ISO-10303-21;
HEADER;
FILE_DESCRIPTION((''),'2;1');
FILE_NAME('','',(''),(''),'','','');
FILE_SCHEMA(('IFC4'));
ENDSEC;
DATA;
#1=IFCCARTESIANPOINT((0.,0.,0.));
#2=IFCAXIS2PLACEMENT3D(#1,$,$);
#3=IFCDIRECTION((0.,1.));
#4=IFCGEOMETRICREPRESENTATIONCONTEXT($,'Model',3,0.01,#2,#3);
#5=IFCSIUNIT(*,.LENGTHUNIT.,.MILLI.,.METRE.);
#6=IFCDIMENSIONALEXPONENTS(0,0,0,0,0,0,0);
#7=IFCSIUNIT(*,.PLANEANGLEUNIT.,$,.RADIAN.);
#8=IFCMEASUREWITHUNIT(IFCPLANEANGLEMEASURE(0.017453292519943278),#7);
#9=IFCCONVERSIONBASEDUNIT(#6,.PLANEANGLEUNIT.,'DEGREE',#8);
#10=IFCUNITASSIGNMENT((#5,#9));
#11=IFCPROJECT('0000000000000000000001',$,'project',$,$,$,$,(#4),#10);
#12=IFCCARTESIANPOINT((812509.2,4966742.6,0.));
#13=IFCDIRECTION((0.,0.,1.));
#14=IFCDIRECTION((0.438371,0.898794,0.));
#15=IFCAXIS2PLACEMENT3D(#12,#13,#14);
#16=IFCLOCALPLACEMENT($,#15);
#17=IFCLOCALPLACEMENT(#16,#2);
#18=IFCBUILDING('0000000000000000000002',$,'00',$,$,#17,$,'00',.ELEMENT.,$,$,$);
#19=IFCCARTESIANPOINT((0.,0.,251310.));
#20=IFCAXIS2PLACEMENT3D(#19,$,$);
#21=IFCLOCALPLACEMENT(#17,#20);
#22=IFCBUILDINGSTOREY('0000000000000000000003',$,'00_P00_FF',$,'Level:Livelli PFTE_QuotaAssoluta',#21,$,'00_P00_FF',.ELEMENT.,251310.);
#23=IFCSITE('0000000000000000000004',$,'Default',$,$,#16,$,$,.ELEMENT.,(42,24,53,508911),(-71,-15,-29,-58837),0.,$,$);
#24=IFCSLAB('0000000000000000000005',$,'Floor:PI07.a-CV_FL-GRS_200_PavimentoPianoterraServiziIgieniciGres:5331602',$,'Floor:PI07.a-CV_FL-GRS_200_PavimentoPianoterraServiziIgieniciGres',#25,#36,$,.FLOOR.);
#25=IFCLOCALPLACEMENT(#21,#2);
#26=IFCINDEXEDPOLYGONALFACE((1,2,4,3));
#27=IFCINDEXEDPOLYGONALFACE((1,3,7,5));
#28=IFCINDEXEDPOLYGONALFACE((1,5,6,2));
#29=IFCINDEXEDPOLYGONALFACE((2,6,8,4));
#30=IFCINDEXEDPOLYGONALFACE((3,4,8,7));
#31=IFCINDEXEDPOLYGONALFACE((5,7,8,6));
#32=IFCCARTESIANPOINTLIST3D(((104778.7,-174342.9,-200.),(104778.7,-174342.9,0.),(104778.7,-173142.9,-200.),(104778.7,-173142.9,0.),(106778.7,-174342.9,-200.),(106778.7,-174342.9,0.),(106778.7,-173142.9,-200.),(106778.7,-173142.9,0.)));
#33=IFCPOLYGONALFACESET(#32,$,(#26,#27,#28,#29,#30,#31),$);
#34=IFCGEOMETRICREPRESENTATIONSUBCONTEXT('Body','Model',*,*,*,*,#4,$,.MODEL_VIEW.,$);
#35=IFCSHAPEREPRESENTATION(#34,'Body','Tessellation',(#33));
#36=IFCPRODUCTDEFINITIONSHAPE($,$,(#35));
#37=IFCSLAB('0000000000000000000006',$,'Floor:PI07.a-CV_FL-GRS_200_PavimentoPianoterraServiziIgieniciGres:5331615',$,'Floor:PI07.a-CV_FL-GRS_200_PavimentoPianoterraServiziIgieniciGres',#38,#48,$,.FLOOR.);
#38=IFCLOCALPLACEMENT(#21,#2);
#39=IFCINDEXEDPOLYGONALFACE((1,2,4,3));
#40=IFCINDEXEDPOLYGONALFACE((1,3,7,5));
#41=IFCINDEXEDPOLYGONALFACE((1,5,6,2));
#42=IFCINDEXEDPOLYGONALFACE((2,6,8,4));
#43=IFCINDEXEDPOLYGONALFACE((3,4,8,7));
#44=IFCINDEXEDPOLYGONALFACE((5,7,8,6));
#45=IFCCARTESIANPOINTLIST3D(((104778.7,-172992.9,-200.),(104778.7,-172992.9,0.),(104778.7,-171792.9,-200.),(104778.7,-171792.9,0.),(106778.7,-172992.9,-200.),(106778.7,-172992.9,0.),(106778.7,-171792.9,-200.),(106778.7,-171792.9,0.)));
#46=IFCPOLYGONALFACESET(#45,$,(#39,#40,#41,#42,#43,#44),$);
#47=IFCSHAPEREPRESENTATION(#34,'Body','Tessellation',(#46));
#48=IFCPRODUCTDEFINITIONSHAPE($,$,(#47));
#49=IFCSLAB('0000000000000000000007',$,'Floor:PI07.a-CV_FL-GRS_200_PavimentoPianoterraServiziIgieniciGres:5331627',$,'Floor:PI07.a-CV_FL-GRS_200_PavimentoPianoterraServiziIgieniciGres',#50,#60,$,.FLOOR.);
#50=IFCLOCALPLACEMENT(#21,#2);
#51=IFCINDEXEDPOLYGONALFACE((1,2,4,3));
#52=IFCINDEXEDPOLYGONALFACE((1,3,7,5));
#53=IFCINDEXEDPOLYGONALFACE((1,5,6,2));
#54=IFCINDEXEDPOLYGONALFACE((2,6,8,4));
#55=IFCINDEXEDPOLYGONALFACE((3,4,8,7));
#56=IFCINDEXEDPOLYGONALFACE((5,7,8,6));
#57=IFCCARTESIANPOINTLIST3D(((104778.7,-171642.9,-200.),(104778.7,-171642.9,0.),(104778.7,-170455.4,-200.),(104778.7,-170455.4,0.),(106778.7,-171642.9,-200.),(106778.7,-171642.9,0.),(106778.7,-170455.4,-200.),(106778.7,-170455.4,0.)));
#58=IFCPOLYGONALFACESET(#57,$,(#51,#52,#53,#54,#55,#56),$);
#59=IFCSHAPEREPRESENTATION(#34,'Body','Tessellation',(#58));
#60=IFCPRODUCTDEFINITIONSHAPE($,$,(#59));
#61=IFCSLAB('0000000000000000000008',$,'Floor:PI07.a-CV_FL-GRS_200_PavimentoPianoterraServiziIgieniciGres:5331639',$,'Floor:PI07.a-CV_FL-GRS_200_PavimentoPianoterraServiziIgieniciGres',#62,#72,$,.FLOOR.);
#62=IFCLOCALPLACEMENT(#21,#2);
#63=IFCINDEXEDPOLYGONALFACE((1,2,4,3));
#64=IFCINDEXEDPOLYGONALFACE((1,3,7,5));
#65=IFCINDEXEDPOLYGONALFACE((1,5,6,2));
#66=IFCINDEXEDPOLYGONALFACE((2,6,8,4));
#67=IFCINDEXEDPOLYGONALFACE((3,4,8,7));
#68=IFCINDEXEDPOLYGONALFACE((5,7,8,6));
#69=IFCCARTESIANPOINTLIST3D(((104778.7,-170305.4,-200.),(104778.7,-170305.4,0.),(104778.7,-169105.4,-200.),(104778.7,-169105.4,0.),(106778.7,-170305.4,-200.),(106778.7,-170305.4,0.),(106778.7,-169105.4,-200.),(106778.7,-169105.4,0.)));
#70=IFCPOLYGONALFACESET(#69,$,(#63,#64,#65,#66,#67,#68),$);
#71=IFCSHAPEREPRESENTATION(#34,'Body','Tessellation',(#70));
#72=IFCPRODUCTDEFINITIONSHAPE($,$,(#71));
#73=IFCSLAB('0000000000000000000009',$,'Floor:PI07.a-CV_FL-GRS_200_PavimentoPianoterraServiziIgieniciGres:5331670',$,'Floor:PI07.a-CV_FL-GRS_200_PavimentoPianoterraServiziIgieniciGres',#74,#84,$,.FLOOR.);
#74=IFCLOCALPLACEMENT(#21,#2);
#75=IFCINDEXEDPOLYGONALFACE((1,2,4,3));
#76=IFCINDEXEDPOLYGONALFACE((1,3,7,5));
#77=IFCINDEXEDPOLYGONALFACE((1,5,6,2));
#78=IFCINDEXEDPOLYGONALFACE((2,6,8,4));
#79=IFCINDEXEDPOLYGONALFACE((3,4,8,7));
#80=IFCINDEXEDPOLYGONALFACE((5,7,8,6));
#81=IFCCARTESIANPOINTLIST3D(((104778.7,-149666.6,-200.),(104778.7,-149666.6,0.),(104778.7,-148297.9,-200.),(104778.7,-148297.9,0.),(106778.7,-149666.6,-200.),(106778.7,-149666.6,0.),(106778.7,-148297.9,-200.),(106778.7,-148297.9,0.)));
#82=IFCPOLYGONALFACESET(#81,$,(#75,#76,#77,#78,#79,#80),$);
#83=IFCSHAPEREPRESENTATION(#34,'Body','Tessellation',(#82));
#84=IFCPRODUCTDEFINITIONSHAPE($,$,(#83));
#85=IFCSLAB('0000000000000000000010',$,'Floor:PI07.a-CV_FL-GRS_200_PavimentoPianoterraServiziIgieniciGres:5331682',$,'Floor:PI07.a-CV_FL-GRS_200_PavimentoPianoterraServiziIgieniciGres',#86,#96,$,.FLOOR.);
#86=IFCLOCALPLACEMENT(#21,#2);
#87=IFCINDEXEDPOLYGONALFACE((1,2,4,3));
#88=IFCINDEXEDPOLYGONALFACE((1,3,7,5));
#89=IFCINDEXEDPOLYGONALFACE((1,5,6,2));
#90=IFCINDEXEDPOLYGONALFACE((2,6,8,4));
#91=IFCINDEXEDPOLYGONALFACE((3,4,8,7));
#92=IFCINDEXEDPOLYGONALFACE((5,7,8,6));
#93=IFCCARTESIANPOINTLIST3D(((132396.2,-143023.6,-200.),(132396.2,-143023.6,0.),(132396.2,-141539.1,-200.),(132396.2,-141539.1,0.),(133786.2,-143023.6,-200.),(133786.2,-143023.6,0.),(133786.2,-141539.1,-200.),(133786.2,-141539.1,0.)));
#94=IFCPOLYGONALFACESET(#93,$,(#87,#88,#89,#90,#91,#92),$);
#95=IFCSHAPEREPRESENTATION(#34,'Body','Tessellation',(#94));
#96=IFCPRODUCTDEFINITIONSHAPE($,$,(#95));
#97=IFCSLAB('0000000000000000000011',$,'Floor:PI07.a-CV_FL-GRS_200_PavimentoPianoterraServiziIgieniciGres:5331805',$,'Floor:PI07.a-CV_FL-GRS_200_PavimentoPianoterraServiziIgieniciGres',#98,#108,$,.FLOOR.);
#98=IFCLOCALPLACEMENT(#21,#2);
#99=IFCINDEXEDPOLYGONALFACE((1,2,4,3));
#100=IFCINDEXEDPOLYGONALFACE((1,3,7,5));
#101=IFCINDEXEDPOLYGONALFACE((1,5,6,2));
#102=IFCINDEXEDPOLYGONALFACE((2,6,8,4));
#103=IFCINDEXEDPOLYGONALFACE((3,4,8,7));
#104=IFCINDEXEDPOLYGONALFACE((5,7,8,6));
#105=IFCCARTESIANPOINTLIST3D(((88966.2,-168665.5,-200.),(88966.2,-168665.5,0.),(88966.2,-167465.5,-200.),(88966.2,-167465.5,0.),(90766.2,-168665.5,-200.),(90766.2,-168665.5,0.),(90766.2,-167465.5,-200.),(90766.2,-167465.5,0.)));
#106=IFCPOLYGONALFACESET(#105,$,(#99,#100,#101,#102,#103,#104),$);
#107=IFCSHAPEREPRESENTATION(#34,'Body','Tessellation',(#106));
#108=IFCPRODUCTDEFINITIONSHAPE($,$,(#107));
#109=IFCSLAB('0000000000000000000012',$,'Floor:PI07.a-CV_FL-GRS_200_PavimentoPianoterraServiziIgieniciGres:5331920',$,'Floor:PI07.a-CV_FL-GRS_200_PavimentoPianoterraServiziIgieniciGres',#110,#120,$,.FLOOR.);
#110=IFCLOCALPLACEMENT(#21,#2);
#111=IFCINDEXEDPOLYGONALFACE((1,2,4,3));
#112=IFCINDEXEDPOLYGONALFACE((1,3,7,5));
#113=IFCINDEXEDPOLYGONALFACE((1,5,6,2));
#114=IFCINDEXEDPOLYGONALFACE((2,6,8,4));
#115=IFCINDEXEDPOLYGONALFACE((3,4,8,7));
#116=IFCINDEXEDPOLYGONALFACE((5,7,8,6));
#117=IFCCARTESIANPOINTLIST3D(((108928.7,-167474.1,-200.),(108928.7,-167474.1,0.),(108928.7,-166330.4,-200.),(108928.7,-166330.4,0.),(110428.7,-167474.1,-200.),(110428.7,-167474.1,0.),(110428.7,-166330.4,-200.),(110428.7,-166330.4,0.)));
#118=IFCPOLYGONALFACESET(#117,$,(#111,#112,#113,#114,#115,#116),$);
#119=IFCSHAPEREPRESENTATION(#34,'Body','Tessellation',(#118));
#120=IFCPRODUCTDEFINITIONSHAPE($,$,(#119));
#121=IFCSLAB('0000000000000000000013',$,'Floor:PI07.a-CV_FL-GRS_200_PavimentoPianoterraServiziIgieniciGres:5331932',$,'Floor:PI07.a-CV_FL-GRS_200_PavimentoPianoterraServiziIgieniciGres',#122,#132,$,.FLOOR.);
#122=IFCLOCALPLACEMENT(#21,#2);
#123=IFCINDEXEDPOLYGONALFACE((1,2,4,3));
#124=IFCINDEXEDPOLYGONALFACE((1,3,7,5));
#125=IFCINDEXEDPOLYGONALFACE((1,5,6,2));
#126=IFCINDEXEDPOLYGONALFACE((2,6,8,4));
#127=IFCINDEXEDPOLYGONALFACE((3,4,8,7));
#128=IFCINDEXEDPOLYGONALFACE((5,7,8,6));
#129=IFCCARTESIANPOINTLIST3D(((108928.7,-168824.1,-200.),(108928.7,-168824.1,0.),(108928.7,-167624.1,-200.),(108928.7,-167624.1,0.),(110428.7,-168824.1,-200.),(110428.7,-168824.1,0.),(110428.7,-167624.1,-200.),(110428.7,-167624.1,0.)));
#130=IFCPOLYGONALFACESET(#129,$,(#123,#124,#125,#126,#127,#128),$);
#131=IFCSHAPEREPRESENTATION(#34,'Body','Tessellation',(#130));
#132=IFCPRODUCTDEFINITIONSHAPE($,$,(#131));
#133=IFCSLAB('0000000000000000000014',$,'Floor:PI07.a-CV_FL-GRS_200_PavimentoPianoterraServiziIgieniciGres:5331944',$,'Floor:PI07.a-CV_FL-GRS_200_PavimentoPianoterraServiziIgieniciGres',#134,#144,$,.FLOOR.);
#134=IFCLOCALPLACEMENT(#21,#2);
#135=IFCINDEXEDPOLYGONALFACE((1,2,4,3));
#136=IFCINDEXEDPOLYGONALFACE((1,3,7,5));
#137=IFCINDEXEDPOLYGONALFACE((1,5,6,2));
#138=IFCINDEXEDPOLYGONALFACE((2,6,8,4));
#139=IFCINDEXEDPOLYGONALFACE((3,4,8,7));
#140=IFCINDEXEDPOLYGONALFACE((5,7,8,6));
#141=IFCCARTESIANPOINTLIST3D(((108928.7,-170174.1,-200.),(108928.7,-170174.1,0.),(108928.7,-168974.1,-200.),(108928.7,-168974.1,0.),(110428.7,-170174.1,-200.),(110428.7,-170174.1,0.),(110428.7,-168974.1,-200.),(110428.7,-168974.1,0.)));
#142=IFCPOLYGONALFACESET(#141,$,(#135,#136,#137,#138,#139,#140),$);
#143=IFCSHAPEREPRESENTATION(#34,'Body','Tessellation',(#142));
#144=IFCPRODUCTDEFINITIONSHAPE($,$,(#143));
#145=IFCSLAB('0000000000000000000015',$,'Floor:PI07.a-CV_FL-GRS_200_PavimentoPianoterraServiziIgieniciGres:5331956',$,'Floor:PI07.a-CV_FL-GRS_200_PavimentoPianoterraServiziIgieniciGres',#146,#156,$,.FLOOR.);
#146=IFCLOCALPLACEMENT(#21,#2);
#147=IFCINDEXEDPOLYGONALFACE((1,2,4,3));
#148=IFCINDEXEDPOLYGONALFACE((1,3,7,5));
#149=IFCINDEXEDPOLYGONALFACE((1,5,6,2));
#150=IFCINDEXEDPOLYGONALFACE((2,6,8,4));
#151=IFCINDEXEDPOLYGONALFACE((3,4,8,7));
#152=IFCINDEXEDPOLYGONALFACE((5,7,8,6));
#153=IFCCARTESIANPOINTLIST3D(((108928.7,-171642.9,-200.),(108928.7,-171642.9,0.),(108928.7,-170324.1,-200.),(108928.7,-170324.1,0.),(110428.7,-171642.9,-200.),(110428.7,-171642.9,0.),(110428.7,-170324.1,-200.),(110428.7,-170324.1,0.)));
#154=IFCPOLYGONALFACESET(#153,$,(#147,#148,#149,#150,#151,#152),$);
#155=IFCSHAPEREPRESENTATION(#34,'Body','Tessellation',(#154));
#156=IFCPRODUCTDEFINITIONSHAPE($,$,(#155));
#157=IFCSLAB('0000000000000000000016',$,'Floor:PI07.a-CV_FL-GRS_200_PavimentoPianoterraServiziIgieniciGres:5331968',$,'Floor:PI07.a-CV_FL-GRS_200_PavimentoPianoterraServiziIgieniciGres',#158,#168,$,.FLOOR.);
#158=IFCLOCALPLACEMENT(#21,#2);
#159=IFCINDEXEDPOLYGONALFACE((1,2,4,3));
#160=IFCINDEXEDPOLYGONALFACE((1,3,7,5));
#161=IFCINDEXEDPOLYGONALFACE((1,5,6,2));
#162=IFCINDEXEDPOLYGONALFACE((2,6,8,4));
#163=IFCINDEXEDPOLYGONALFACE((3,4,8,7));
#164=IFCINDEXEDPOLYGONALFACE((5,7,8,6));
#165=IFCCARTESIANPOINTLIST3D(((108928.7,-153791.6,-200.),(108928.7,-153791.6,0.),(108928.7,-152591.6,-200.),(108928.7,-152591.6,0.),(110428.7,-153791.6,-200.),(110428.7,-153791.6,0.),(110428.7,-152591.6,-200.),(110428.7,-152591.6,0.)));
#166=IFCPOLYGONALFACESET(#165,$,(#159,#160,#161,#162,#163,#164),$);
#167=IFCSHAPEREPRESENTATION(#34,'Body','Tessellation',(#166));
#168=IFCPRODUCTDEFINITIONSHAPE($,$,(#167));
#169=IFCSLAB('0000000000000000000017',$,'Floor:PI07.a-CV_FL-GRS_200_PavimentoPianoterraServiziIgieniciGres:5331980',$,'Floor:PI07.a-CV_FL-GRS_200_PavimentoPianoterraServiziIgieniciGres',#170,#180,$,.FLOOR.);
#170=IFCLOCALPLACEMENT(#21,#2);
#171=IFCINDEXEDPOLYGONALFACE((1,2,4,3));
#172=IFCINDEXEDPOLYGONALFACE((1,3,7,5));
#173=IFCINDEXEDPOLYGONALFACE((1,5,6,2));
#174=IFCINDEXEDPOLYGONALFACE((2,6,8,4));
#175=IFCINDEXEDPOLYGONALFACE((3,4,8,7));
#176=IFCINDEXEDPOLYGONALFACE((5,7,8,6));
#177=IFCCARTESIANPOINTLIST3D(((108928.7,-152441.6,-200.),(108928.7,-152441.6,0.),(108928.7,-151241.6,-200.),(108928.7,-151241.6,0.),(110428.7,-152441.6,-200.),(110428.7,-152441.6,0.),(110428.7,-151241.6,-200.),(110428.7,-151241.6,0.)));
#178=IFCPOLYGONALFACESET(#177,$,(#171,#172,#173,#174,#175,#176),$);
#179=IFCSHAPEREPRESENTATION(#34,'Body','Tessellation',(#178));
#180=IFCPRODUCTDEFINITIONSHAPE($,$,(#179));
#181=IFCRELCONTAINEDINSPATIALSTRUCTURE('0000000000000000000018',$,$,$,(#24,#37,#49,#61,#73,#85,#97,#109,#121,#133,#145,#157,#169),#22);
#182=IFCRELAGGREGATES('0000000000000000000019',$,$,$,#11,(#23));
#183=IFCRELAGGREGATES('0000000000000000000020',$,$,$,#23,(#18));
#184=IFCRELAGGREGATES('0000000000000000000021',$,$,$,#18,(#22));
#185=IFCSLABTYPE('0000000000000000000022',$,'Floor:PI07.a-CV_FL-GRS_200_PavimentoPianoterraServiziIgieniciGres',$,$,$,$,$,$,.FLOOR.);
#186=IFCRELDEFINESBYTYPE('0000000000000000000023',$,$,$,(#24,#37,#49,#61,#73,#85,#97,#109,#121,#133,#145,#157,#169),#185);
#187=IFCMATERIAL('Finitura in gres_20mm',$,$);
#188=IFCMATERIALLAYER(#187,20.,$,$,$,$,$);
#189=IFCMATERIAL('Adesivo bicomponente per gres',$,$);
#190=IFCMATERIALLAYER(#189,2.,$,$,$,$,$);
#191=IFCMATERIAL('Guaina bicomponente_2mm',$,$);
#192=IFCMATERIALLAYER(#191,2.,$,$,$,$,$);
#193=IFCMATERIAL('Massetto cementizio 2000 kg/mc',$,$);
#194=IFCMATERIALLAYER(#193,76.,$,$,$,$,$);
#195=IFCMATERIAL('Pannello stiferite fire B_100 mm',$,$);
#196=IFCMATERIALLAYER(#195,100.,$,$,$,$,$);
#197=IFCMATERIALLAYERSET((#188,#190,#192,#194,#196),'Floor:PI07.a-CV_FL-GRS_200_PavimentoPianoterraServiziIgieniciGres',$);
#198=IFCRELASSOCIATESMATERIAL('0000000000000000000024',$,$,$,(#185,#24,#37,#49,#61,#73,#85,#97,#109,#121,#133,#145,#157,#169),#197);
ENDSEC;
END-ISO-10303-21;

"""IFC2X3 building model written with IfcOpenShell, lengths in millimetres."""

from ifc_helpers import new_model, entity, si_unit, converted_unit, direction, frame, frame_2d, origin, origin_2d_with_axis, place, context, subcontext, project, spatial, rectangle, extrude, material, layer, layer_set, layer_usage, type_object, element, save


model = new_model("IFC2X3")

# Units and contexts
model_context = context("Model", 3, precision=0.01, world=origin(), true_north=direction((0.0, 1.0)))
body_context = subcontext(model_context, "Body", "Model", "MODEL_VIEW")
ifc_project = project(units=[si_unit("LENGTHUNIT", "METRE", prefix="MILLI"), converted_unit("PLANEANGLEUNIT", "DEGREE", entity("IfcPlaneAngleMeasure", 0.017453292519943278), si_unit("PLANEANGLEUNIT", "RADIAN"), dimensions=[0, 0, 0, 0, 0, 0, 0])], contexts=[model_context])

# Site, building, storey
site_placement = place(None, frame((812509.2, 4966742.6, 0.0), z_axis=(0.0, 0.0, 1.0), x_axis=(0.438371, 0.898794, 0.0)))
site = spatial("IfcSite", under=ifc_project, at=site_placement, Name="Default", CompositionType="ELEMENT", RefLatitude=(42, 24, 53, 508911), RefLongitude=(-71, -15, -29, -58837), RefElevation=0.0)
building_placement = place(site_placement, origin())
building = spatial("IfcBuilding", under=site, at=building_placement, Name="00", LongName="00", CompositionType="ELEMENT")
storey_placement = place(building_placement, frame((0.0, 0.0, 251310.0)))
storey = spatial("IfcBuildingStorey", under=building, at=storey_placement, Name="00_P00_FF", ObjectType="Level:Livelli PFTE_QuotaAssoluta", LongName="00_P00_FF", CompositionType="ELEMENT", Elevation=251310.0)

# Slabs
ifc_material_1 = material(Name="Pannello stiferite fire B_100 mm")
ifc_material_2 = material(Name="Massetto cementizio 2000 kg/mc")
ifc_material_3 = material(Name="Finitura in gres_20mm")
ifc_layer_1 = layer(ifc_material_3, 20.0)
ifc_material_4 = material(Name="Adesivo bicomponente per gres")
ifc_layer_2 = layer(ifc_material_4, 2.0)
ifc_material_5 = material(Name="Guaina bicomponente_2mm")
ifc_layer_3 = layer(ifc_material_5, 2.0)
ifc_layer_4 = layer(ifc_material_2, 76.0)
ifc_layer_5 = layer(ifc_material_1, 100.0)
ifc_layer_set_1 = layer_set([ifc_layer_1, ifc_layer_2, ifc_layer_3, ifc_layer_4, ifc_layer_5], Name="Floor:PI07.a-CV_FL-GRS_200_PavimentoPianoterraServiziIgieniciGres")
slab_type_1 = type_object("IfcSlabType", Name="Floor:PI07.a-CV_FL-GRS_200_PavimentoPianoterraServiziIgieniciGres", PredefinedType="FLOOR", material=ifc_layer_set_1)
ifc_layer_usage_1 = layer_usage(ifc_layer_set_1, "AXIS3", "POSITIVE", 0.0)
slab_1_placement = place(storey_placement, origin())
element("IfcSlab", 1, at=slab_1_placement, inside=storey, type_object=slab_type_1, material=ifc_layer_usage_1, Name="Floor:PI07.a-CV_FL-GRS_200_PavimentoPianoterraServiziIgieniciGres:5331602", ObjectType="Floor:PI07.a-CV_FL-GRS_200_PavimentoPianoterraServiziIgieniciGres", PredefinedType="FLOOR", context=body_context, shape_type="SweptSolid", body=[
    extrude(rectangle(XDim=1200.0, YDim=2000.0, at=origin_2d_with_axis()), frame((105778.7, -173742.9, 0.0), z_axis=(0.0, 0.0, -1.0), x_axis=(0.0, 1.0, 0.0)), (0.0, 0.0, 1.0), 200.0),
])
ifc_layer_usage_2 = layer_usage(ifc_layer_set_1, "AXIS3", "POSITIVE", 0.0)
slab_2_placement = place(storey_placement, origin())
element("IfcSlab", 2, at=slab_2_placement, inside=storey, type_object=slab_type_1, material=ifc_layer_usage_2, Name="Floor:PI07.a-CV_FL-GRS_200_PavimentoPianoterraServiziIgieniciGres:5331615", ObjectType="Floor:PI07.a-CV_FL-GRS_200_PavimentoPianoterraServiziIgieniciGres", PredefinedType="FLOOR", context=body_context, shape_type="SweptSolid", body=[
    extrude(rectangle(XDim=1200.0, YDim=2000.0, at=origin_2d_with_axis()), frame((105778.7, -172392.9, 0.0), z_axis=(0.0, 0.0, -1.0), x_axis=(0.0, 1.0, 0.0)), (0.0, 0.0, 1.0), 200.0),
])
ifc_layer_usage_3 = layer_usage(ifc_layer_set_1, "AXIS3", "POSITIVE", 0.0)
slab_3_placement = place(storey_placement, origin())
element("IfcSlab", 3, at=slab_3_placement, inside=storey, type_object=slab_type_1, material=ifc_layer_usage_3, Name="Floor:PI07.a-CV_FL-GRS_200_PavimentoPianoterraServiziIgieniciGres:5331627", ObjectType="Floor:PI07.a-CV_FL-GRS_200_PavimentoPianoterraServiziIgieniciGres", PredefinedType="FLOOR", context=body_context, shape_type="SweptSolid", body=[
    extrude(rectangle(XDim=1187.5, YDim=2000.0, at=frame_2d((0.0, 0.0), x_axis=(1.0, 0.0))), frame((105778.7, -171049.1, 0.0), z_axis=(0.0, 0.0, -1.0), x_axis=(0.0, 1.0, 0.0)), (0.0, 0.0, 1.0), 200.0),
])
ifc_layer_usage_4 = layer_usage(ifc_layer_set_1, "AXIS3", "POSITIVE", 0.0)
slab_4_placement = place(storey_placement, origin())
element("IfcSlab", 4, at=slab_4_placement, inside=storey, type_object=slab_type_1, material=ifc_layer_usage_4, Name="Floor:PI07.a-CV_FL-GRS_200_PavimentoPianoterraServiziIgieniciGres:5331639", ObjectType="Floor:PI07.a-CV_FL-GRS_200_PavimentoPianoterraServiziIgieniciGres", PredefinedType="FLOOR", context=body_context, shape_type="SweptSolid", body=[
    extrude(rectangle(XDim=1200.0, YDim=2000.0, at=frame_2d((0.0, 0.0), x_axis=(1.0, 0.0))), frame((105778.7, -169705.4, 0.0), z_axis=(0.0, 0.0, -1.0), x_axis=(0.0, 1.0, 0.0)), (0.0, 0.0, 1.0), 200.0),
])
ifc_layer_usage_5 = layer_usage(ifc_layer_set_1, "AXIS3", "POSITIVE", 0.0)
slab_5_placement = place(storey_placement, origin())
element("IfcSlab", 5, at=slab_5_placement, inside=storey, type_object=slab_type_1, material=ifc_layer_usage_5, Name="Floor:PI07.a-CV_FL-GRS_200_PavimentoPianoterraServiziIgieniciGres:5331670", ObjectType="Floor:PI07.a-CV_FL-GRS_200_PavimentoPianoterraServiziIgieniciGres", PredefinedType="FLOOR", context=body_context, shape_type="SweptSolid", body=[
    extrude(rectangle(XDim=1368.7, YDim=2000.0, at=frame_2d((0.0, 0.0), x_axis=(1.0, 0.0))), frame((105778.7, -148982.3, 0.0), z_axis=(0.0, 0.0, -1.0), x_axis=(0.0, 1.0, 0.0)), (0.0, 0.0, 1.0), 200.0),
])
ifc_layer_usage_6 = layer_usage(ifc_layer_set_1, "AXIS3", "POSITIVE", 0.0)
slab_6_placement = place(storey_placement, origin())
element("IfcSlab", 6, at=slab_6_placement, inside=storey, type_object=slab_type_1, material=ifc_layer_usage_6, Name="Floor:PI07.a-CV_FL-GRS_200_PavimentoPianoterraServiziIgieniciGres:5331682", ObjectType="Floor:PI07.a-CV_FL-GRS_200_PavimentoPianoterraServiziIgieniciGres", PredefinedType="FLOOR", context=body_context, shape_type="SweptSolid", body=[
    extrude(rectangle(XDim=1484.5, YDim=1390.0, at=origin_2d_with_axis()), frame((133091.2, -142281.4, 0.0), z_axis=(0.0, 0.0, -1.0), x_axis=(0.0, 1.0, 0.0)), (0.0, 0.0, 1.0), 200.0),
])
ifc_layer_usage_7 = layer_usage(ifc_layer_set_1, "AXIS3", "POSITIVE", 0.0)
slab_7_placement = place(storey_placement, origin())
element("IfcSlab", 7, at=slab_7_placement, inside=storey, type_object=slab_type_1, material=ifc_layer_usage_7, Name="Floor:PI07.a-CV_FL-GRS_200_PavimentoPianoterraServiziIgieniciGres:5331805", ObjectType="Floor:PI07.a-CV_FL-GRS_200_PavimentoPianoterraServiziIgieniciGres", PredefinedType="FLOOR", context=body_context, shape_type="SweptSolid", body=[
    extrude(rectangle(XDim=1200.0, YDim=1800.0, at=origin_2d_with_axis()), frame((89866.2, -168065.5, 0.0), z_axis=(0.0, 0.0, -1.0), x_axis=(0.0, 1.0, 0.0)), (0.0, 0.0, 1.0), 200.0),
])
ifc_layer_usage_8 = layer_usage(ifc_layer_set_1, "AXIS3", "POSITIVE", 0.0)
slab_8_placement = place(storey_placement, origin())
element("IfcSlab", 8, at=slab_8_placement, inside=storey, type_object=slab_type_1, material=ifc_layer_usage_8, Name="Floor:PI07.a-CV_FL-GRS_200_PavimentoPianoterraServiziIgieniciGres:5331920", ObjectType="Floor:PI07.a-CV_FL-GRS_200_PavimentoPianoterraServiziIgieniciGres", PredefinedType="FLOOR", context=body_context, shape_type="SweptSolid", body=[
    extrude(rectangle(XDim=1143.8, YDim=1500.0, at=frame_2d((0.0, 0.0), x_axis=(1.0, 0.0))), frame((109678.7, -166902.3, 0.0), z_axis=(0.0, 0.0, -1.0), x_axis=(0.0, 1.0, 0.0)), (0.0, 0.0, 1.0), 200.0),
])
ifc_layer_usage_9 = layer_usage(ifc_layer_set_1, "AXIS3", "POSITIVE", 0.0)
slab_9_placement = place(storey_placement, origin())
element("IfcSlab", 9, at=slab_9_placement, inside=storey, type_object=slab_type_1, material=ifc_layer_usage_9, Name="Floor:PI07.a-CV_FL-GRS_200_PavimentoPianoterraServiziIgieniciGres:5331932", ObjectType="Floor:PI07.a-CV_FL-GRS_200_PavimentoPianoterraServiziIgieniciGres", PredefinedType="FLOOR", context=body_context, shape_type="SweptSolid", body=[
    extrude(rectangle(XDim=1200.0, YDim=1500.0, at=origin_2d_with_axis()), frame((109678.7, -168224.1, 0.0), z_axis=(0.0, 0.0, -1.0), x_axis=(0.0, 1.0, 0.0)), (0.0, 0.0, 1.0), 200.0),
])
ifc_layer_usage_10 = layer_usage(ifc_layer_set_1, "AXIS3", "POSITIVE", 0.0)
slab_10_placement = place(storey_placement, origin())
element("IfcSlab", 10, at=slab_10_placement, inside=storey, type_object=slab_type_1, material=ifc_layer_usage_10, Name="Floor:PI07.a-CV_FL-GRS_200_PavimentoPianoterraServiziIgieniciGres:5331944", ObjectType="Floor:PI07.a-CV_FL-GRS_200_PavimentoPianoterraServiziIgieniciGres", PredefinedType="FLOOR", context=body_context, shape_type="SweptSolid", body=[
    extrude(rectangle(XDim=1200.0, YDim=1500.0, at=origin_2d_with_axis()), frame((109678.7, -169574.1, 0.0), z_axis=(0.0, 0.0, -1.0), x_axis=(0.0, 1.0, 0.0)), (0.0, 0.0, 1.0), 200.0),
])
ifc_layer_usage_11 = layer_usage(ifc_layer_set_1, "AXIS3", "POSITIVE", 0.0)
slab_11_placement = place(storey_placement, origin())
element("IfcSlab", 11, at=slab_11_placement, inside=storey, type_object=slab_type_1, material=ifc_layer_usage_11, Name="Floor:PI07.a-CV_FL-GRS_200_PavimentoPianoterraServiziIgieniciGres:5331956", ObjectType="Floor:PI07.a-CV_FL-GRS_200_PavimentoPianoterraServiziIgieniciGres", PredefinedType="FLOOR", context=body_context, shape_type="SweptSolid", body=[
    extrude(rectangle(XDim=1318.8, YDim=1500.0, at=frame_2d((0.0, 0.0), x_axis=(1.0, 0.0))), frame((109678.7, -170983.5, 0.0), z_axis=(0.0, 0.0, -1.0), x_axis=(0.0, 1.0, 0.0)), (0.0, 0.0, 1.0), 200.0),
])
ifc_layer_usage_12 = layer_usage(ifc_layer_set_1, "AXIS3", "POSITIVE", 0.0)
slab_12_placement = place(storey_placement, origin())
element("IfcSlab", 12, at=slab_12_placement, inside=storey, type_object=slab_type_1, material=ifc_layer_usage_12, Name="Floor:PI07.a-CV_FL-GRS_200_PavimentoPianoterraServiziIgieniciGres:5331968", ObjectType="Floor:PI07.a-CV_FL-GRS_200_PavimentoPianoterraServiziIgieniciGres", PredefinedType="FLOOR", context=body_context, shape_type="SweptSolid", body=[
    extrude(rectangle(XDim=1200.0, YDim=1500.0, at=frame_2d((0.0, 0.0), x_axis=(1.0, 0.0))), frame((109678.7, -153191.6, 0.0), z_axis=(0.0, 0.0, -1.0), x_axis=(0.0, 1.0, 0.0)), (0.0, 0.0, 1.0), 200.0),
])
ifc_layer_usage_13 = layer_usage(ifc_layer_set_1, "AXIS3", "POSITIVE", 0.0)
slab_13_placement = place(storey_placement, origin())
element("IfcSlab", 13, at=slab_13_placement, inside=storey, type_object=slab_type_1, material=ifc_layer_usage_13, Name="Floor:PI07.a-CV_FL-GRS_200_PavimentoPianoterraServiziIgieniciGres:5331980", ObjectType="Floor:PI07.a-CV_FL-GRS_200_PavimentoPianoterraServiziIgieniciGres", PredefinedType="FLOOR", context=body_context, shape_type="SweptSolid", body=[
    extrude(rectangle(XDim=1200.0, YDim=1500.0, at=origin_2d_with_axis()), frame((109678.7, -151841.6, 0.0), z_axis=(0.0, 0.0, -1.0), x_axis=(0.0, 1.0, 0.0)), (0.0, 0.0, 1.0), 200.0),
])

save(model, "model.ifc")
